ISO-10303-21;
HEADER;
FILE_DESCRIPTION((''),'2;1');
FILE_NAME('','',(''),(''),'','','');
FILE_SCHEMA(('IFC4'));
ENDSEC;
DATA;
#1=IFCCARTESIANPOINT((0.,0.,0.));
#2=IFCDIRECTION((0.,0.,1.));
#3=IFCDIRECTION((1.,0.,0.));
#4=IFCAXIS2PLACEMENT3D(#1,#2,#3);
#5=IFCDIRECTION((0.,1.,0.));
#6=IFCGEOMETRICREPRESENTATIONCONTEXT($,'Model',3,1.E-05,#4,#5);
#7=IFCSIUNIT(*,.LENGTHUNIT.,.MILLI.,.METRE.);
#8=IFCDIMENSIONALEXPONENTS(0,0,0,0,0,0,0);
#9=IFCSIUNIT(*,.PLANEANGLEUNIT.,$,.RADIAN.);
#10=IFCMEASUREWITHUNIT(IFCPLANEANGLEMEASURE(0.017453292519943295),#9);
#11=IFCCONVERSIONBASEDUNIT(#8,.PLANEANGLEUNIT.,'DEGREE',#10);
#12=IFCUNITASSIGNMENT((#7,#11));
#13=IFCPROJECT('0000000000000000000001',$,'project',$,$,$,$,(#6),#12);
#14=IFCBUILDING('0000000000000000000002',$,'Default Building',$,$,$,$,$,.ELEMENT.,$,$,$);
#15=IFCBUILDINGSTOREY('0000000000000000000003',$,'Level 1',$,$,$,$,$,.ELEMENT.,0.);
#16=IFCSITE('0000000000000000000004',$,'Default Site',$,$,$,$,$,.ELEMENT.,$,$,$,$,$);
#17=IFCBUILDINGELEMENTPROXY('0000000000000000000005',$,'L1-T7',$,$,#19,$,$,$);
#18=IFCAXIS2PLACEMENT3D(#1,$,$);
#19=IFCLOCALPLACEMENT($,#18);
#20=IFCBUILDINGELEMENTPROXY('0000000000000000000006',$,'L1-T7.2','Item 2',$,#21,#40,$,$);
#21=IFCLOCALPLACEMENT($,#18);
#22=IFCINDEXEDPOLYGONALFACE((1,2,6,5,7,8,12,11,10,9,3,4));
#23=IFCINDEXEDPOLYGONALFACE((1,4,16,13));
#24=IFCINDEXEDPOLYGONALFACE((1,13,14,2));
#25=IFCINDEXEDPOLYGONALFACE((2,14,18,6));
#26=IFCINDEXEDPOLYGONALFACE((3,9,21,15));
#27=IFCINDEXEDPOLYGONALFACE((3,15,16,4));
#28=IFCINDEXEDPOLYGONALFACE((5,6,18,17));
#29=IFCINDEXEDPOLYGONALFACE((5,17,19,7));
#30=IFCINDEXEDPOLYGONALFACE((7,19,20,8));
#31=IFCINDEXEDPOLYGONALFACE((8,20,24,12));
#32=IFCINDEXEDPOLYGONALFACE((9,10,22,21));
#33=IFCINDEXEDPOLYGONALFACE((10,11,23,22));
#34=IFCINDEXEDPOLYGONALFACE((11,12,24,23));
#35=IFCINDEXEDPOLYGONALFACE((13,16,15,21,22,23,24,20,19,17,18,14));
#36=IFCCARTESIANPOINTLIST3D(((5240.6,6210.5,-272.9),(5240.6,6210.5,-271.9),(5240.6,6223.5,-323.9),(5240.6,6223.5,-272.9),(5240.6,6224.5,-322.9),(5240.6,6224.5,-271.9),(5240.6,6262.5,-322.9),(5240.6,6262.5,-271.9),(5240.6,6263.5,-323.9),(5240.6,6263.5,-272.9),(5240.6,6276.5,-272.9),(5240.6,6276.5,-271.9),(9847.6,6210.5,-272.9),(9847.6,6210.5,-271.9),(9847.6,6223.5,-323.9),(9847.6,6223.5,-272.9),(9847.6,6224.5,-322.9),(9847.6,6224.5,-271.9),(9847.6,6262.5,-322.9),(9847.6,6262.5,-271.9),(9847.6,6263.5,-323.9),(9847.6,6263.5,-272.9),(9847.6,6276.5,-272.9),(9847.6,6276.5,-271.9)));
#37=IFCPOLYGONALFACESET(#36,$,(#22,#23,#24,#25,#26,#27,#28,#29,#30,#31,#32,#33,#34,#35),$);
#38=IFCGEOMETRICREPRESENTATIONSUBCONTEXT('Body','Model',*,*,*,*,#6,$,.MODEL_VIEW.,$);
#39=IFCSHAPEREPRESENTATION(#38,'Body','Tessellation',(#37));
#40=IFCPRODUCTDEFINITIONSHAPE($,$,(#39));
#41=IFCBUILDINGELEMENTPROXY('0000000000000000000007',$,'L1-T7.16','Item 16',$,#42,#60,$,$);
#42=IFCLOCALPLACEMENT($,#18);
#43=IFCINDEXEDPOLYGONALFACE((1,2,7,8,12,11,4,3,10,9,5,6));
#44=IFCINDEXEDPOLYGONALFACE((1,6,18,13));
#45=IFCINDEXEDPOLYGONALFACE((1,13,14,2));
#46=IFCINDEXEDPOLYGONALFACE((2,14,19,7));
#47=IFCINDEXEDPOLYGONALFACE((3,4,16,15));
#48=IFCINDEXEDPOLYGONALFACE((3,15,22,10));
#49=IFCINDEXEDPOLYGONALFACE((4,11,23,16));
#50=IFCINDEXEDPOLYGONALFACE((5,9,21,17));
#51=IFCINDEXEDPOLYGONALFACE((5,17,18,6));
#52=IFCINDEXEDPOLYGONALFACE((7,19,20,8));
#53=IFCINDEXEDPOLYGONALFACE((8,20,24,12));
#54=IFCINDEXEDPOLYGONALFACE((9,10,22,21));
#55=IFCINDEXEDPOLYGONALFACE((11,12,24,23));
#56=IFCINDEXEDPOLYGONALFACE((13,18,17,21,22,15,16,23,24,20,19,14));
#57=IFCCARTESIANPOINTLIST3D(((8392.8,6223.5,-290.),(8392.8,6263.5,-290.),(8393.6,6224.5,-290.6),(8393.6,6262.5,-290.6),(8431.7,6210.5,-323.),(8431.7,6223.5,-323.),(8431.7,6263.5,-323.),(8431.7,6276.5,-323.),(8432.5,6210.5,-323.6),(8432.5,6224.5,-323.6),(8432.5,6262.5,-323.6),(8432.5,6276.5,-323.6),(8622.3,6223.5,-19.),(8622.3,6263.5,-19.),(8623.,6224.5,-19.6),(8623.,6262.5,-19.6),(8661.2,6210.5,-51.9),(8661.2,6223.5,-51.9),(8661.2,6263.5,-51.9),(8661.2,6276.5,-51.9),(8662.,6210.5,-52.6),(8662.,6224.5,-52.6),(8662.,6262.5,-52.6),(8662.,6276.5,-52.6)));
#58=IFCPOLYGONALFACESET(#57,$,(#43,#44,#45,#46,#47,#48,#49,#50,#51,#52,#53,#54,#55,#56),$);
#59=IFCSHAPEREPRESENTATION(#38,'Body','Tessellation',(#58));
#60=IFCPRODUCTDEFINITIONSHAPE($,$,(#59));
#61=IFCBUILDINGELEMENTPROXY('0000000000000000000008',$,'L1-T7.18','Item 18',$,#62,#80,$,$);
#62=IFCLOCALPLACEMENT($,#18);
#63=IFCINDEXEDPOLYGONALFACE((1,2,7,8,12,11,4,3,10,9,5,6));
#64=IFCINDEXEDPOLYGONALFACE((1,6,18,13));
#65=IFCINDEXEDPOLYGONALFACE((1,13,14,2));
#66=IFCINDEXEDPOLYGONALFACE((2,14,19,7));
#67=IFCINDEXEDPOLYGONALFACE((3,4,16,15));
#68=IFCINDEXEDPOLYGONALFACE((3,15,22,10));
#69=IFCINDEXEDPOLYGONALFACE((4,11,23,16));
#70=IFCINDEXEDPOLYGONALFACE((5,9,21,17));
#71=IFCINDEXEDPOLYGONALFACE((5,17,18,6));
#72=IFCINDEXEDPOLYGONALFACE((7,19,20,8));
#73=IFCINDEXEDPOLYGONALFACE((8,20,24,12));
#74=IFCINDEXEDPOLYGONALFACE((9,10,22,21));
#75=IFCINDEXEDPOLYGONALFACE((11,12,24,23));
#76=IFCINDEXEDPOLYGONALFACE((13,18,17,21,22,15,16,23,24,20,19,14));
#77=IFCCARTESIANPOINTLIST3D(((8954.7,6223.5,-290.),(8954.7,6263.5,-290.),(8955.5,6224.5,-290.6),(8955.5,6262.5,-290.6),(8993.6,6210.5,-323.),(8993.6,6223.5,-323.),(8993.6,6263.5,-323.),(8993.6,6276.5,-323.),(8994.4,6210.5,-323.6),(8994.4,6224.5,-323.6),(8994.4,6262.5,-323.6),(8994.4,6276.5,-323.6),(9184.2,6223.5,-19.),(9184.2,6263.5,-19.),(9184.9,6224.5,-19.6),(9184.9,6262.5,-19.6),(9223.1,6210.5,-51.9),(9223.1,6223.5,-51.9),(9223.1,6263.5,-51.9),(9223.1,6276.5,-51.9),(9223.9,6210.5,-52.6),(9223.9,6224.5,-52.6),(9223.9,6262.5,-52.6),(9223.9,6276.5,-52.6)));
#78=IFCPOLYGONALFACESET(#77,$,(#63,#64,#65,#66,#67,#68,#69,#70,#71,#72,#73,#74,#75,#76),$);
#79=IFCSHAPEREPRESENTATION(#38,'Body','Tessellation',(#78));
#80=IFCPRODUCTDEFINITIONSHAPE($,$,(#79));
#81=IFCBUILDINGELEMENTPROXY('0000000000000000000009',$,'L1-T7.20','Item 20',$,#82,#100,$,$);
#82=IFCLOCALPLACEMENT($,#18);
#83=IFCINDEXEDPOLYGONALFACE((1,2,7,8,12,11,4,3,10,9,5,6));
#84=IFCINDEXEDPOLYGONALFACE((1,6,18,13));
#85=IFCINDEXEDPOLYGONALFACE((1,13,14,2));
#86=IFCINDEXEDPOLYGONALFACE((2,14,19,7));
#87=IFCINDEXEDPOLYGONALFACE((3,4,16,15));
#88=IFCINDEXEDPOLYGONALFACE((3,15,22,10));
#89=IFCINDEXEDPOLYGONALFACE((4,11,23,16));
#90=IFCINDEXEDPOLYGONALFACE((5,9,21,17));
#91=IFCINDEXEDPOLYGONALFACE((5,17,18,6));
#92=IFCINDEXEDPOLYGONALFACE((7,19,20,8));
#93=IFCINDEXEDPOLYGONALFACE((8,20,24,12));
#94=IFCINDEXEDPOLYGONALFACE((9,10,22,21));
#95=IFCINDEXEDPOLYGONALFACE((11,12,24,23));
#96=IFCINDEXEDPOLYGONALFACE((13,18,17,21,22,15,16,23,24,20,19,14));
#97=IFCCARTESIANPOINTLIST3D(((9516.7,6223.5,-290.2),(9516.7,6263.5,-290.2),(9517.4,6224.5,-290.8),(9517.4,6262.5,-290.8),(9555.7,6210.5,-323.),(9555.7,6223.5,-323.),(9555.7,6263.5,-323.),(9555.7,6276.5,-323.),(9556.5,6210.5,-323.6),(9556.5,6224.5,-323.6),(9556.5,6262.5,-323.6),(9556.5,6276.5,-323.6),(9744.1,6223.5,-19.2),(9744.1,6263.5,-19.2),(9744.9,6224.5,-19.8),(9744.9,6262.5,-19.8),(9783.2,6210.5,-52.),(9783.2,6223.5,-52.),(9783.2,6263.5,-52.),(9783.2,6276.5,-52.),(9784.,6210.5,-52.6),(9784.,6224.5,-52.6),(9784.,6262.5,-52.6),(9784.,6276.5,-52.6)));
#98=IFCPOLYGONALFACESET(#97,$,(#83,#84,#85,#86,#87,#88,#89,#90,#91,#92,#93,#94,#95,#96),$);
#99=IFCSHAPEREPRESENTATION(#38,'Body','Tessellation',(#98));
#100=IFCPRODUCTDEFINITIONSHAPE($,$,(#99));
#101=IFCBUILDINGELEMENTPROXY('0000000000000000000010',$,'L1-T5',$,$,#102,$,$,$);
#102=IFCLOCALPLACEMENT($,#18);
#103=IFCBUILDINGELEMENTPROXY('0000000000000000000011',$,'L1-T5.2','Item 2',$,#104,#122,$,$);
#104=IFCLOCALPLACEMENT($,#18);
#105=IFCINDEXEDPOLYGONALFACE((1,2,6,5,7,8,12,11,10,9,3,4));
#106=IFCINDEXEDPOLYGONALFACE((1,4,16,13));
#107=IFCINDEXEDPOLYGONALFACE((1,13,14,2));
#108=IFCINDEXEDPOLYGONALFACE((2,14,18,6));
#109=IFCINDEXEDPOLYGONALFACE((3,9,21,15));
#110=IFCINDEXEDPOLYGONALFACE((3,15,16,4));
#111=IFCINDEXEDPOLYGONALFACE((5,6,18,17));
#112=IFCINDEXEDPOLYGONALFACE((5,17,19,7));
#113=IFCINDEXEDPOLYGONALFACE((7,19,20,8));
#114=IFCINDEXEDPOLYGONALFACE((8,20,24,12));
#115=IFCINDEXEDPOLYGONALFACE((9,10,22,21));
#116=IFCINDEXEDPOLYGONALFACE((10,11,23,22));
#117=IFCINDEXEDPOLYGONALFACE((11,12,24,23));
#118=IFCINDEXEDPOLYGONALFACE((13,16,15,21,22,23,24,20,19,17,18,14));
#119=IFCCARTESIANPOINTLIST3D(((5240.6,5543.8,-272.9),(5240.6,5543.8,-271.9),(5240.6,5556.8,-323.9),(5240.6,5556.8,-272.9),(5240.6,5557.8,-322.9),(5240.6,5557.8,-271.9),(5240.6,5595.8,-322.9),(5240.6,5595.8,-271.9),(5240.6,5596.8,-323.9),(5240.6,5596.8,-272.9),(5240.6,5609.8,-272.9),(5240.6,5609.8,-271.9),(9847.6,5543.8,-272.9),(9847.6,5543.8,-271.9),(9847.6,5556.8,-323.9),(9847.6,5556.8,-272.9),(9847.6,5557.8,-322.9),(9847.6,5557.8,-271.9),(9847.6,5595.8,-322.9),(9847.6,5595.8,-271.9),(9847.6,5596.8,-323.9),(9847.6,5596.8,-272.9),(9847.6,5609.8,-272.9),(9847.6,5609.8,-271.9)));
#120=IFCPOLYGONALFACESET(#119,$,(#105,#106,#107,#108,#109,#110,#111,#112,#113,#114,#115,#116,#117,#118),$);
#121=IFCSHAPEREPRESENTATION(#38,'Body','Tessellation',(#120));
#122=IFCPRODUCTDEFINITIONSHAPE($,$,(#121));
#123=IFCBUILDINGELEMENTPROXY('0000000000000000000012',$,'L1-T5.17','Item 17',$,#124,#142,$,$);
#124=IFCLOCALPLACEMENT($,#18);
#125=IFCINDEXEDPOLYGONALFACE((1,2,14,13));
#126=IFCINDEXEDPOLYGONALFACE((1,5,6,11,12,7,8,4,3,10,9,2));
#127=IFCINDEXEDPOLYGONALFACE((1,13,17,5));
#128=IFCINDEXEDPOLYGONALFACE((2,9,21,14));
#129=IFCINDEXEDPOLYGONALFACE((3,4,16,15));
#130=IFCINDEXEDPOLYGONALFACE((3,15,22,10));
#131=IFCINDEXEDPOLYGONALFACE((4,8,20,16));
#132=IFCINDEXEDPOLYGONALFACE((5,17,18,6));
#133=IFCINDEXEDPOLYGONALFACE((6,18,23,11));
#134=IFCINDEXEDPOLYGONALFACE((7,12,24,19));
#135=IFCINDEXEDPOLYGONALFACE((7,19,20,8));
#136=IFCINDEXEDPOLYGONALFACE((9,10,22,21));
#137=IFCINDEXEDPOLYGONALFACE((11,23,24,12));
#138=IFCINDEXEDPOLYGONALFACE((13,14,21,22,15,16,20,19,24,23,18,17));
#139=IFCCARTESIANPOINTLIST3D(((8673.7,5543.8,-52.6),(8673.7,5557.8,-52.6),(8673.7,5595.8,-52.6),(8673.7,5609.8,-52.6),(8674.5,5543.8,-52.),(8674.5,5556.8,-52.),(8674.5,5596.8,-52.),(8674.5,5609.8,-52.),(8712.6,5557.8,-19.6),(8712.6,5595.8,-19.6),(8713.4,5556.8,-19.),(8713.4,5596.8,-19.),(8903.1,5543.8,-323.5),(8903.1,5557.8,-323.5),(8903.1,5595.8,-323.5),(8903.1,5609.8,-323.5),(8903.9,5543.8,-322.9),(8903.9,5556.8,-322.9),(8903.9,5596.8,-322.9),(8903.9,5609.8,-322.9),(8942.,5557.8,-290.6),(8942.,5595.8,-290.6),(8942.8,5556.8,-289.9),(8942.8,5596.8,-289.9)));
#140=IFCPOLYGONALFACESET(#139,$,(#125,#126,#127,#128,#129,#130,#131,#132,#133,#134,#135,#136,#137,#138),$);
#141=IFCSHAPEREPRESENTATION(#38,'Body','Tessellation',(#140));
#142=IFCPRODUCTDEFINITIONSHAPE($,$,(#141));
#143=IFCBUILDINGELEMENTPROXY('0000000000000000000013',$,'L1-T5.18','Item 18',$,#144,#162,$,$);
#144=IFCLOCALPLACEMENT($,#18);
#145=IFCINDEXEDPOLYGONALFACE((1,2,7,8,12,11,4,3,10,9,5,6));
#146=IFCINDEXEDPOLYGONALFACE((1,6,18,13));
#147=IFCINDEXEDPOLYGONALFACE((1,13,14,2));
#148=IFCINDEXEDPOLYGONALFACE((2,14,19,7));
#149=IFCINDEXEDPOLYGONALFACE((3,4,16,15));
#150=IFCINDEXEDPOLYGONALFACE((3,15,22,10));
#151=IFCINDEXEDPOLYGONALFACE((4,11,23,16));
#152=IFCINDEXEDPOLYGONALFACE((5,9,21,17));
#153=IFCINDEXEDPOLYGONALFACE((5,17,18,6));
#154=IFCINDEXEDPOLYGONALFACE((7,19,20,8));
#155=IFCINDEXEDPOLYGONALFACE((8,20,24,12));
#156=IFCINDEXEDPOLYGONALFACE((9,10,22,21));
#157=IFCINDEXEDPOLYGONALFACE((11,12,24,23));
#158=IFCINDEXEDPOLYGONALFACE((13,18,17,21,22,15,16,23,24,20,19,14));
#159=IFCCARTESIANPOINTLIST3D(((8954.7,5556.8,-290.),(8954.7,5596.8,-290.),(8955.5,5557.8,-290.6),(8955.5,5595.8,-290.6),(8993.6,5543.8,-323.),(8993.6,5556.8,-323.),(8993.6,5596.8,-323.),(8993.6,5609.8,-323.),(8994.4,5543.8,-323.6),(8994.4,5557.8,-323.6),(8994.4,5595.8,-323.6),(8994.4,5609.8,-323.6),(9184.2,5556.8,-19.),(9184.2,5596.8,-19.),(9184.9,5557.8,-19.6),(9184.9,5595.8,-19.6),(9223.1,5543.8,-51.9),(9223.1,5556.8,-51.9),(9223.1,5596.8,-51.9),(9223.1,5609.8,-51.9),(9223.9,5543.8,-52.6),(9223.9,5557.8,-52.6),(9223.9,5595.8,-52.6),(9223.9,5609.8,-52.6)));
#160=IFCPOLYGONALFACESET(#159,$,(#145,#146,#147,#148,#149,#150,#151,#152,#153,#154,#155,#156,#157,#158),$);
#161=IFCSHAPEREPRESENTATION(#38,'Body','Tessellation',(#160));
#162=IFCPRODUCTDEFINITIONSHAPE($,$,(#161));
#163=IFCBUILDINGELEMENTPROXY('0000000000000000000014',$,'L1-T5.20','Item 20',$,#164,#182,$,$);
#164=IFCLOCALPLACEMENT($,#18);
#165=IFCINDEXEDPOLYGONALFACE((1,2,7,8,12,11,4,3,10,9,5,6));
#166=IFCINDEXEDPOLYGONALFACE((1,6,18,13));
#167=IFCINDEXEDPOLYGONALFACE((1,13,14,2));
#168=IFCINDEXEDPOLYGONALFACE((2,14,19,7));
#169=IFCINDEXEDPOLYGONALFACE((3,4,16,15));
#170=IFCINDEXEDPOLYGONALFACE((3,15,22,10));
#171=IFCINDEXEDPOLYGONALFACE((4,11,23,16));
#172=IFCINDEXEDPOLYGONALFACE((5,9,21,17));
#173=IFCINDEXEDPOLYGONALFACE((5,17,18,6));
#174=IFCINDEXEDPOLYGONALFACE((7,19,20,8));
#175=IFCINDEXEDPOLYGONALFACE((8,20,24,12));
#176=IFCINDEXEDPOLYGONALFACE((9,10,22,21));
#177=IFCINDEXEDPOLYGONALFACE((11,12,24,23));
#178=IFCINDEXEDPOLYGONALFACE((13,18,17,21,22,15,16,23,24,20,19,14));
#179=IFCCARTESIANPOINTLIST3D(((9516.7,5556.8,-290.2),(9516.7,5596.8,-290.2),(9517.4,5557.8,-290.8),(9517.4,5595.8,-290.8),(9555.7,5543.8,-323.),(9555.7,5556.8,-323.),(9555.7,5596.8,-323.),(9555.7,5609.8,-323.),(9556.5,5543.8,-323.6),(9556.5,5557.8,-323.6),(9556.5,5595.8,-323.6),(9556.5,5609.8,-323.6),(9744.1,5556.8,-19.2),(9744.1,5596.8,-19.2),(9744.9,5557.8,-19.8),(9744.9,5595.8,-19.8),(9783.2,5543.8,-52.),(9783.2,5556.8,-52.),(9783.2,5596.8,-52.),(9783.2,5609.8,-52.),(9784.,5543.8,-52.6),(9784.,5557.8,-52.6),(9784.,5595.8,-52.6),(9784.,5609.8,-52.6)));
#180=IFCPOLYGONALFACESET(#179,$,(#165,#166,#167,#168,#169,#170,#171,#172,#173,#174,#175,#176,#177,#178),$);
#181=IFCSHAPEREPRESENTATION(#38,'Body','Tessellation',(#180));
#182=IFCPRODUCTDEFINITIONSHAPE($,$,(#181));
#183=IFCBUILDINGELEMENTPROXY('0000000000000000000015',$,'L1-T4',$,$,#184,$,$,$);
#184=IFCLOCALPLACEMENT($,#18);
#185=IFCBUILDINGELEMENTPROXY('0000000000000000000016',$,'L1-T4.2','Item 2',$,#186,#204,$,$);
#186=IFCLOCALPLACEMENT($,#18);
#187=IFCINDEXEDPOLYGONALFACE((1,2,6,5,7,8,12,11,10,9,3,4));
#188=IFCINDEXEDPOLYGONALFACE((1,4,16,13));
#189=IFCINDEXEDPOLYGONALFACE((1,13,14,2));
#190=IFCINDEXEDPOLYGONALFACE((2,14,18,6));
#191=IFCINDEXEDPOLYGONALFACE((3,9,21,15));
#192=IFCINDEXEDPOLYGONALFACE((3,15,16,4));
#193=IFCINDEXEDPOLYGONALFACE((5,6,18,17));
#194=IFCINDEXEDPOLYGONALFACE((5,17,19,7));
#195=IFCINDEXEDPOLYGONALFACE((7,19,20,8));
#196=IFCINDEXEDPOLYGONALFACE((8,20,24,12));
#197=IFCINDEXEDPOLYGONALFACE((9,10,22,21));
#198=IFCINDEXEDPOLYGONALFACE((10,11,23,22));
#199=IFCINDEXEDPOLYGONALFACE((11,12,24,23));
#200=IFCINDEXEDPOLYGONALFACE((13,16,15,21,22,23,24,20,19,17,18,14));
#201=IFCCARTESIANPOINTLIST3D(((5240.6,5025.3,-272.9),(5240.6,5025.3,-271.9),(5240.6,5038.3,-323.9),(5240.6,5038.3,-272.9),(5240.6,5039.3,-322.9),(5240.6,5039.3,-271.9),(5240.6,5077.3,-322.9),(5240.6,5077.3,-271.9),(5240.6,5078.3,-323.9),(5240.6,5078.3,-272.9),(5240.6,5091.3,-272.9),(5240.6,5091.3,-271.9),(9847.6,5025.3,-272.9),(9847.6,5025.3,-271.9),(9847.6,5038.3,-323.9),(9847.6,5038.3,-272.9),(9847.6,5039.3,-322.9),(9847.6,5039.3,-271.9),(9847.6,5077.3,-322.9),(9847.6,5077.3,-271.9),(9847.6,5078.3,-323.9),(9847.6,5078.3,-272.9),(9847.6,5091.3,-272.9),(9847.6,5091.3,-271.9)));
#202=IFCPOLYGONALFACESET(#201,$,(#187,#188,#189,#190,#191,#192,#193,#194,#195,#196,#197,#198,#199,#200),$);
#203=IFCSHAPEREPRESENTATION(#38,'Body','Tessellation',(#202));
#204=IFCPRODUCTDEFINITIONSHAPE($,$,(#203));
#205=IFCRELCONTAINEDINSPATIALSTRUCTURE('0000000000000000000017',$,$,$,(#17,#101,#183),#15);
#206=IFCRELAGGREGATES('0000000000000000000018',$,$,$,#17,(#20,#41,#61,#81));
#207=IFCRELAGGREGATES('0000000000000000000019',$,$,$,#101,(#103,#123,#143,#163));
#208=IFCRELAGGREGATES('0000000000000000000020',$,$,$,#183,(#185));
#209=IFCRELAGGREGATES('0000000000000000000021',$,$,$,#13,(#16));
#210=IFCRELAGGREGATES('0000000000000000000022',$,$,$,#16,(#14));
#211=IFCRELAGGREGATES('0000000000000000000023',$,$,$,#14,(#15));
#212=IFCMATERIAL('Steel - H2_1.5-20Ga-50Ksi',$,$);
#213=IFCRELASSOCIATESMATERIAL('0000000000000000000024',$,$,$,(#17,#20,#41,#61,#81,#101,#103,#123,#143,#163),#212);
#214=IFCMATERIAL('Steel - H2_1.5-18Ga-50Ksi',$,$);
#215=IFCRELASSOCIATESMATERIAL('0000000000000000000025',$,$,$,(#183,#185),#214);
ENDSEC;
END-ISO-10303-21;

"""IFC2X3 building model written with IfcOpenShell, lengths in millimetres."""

from ifc_helpers import new_model, entity, si_unit, converted_unit, direction, frame, origin, origin_with_axes, place, context, subcontext, project, spatial, polyline, outline, extrude, material, element, aggregate, save


model = new_model("IFC2X3")

# Units and contexts
model_context = context("Model", 3, precision=1e-05, world=origin_with_axes(), true_north=direction((0.0, 1.0, 0.0)))
body_context = subcontext(model_context, "Body", "Model", "MODEL_VIEW")
ifc_project = project(units=[si_unit("LENGTHUNIT", "METRE", prefix="MILLI"), converted_unit("PLANEANGLEUNIT", "DEGREE", entity("IfcPlaneAngleMeasure", 0.017453292519943295), si_unit("PLANEANGLEUNIT", "RADIAN"), dimensions=[0, 0, 0, 0, 0, 0, 0])], contexts=[model_context])

# Site, building, storey
site = spatial("IfcSite", under=ifc_project, Name="Default Site", CompositionType="ELEMENT")
building = spatial("IfcBuilding", under=site, Name="Default Building", CompositionType="ELEMENT")
storey = spatial("IfcBuildingStorey", under=building, Name="Level 1", CompositionType="ELEMENT", Elevation=0.0)

# Building element proxies
ifc_material_1 = material(Name="Steel - H2_1.5-20Ga-50Ksi")
proxy_1 = element("IfcBuildingElementProxy", 1, inside=storey, material=ifc_material_1, Name="L1-T7")
proxy_2_placement = place(None, frame((9847.6, 6210.5, -271.9), z_axis=(-1.0, 0.0, 0.0), x_axis=(0.0, 108.0, 0.0)))
proxy_2 = element("IfcBuildingElementProxy", 2, at=proxy_2_placement, material=ifc_material_1, Name="L1-T7.2", Description="Item 2", context=body_context, shape_type="SweptSolid", body=[
    extrude(outline(polyline([(0.0, 0.0), (14.0, 0.0), (14.0, 51.0), (52.0, 51.0), (52.0, 0.0), (66.0, 0.0), (66.0, 1.0), (53.0, 1.0), (53.0, 52.0), (13.0, 52.0), (13.0, 1.0), (0.0, 1.0), (0.0, 0.0)])), origin(), (0.0, 0.0, 1.0), 4607.0),
])
proxy_3_placement = place(None, frame((8432.5, 6210.5, -323.6), z_axis=(0.646, 0.0, 0.763), x_axis=(0.0, 108.0, 0.0)))
proxy_3 = element("IfcBuildingElementProxy", 3, at=proxy_3_placement, material=ifc_material_1, Name="L1-T7.16", Description="Item 16", context=body_context, shape_type="SweptSolid", body=[
    extrude(outline(polyline([(0.0, 0.0), (14.0, 0.0), (14.0, 51.0), (52.0, 51.0), (52.0, 0.0), (66.0, 0.0), (66.0, 1.0), (53.0, 1.0), (53.0, 52.0), (13.0, 52.0), (13.0, 1.0), (0.0, 1.0), (0.0, 0.0)])), origin(), (0.0, 0.0, 1.0), 355.1),
])
proxy_4_placement = place(None, frame((8994.4, 6210.5, -323.6), z_axis=(0.646, 0.0, 0.763), x_axis=(0.0, 108.0, 0.0)))
proxy_4 = element("IfcBuildingElementProxy", 4, at=proxy_4_placement, material=ifc_material_1, Name="L1-T7.18", Description="Item 18", context=body_context, shape_type="SweptSolid", body=[
    extrude(outline(polyline([(0.0, 0.0), (14.0, 0.0), (14.0, 51.0), (52.0, 51.0), (52.0, 0.0), (66.0, 0.0), (66.0, 1.0), (53.0, 1.0), (53.0, 52.0), (13.0, 52.0), (13.0, 1.0), (0.0, 1.0), (0.0, 0.0)])), origin(), (0.0, 0.0, 1.0), 355.1),
])
proxy_5_placement = place(None, frame((9556.5, 6210.5, -323.6), z_axis=(0.643, 0.0, 0.766), x_axis=(0.0, 108.0, 0.0)))
proxy_5 = element("IfcBuildingElementProxy", 5, at=proxy_5_placement, material=ifc_material_1, Name="L1-T7.20", Description="Item 20", context=body_context, shape_type="SweptSolid", body=[
    extrude(outline(polyline([(0.0, 0.0), (14.0, 0.0), (14.0, 51.0), (52.0, 51.0), (52.0, 0.0), (66.0, 0.0), (66.0, 1.0), (53.0, 1.0), (53.0, 52.0), (13.0, 52.0), (13.0, 1.0), (0.0, 1.0), (0.0, 0.0)])), origin(), (0.0, 0.0, 1.0), 353.8),
])
aggregate(proxy_1, [proxy_2, proxy_3, proxy_4, proxy_5])
proxy_6 = element("IfcBuildingElementProxy", 6, inside=storey, material=ifc_material_1, Name="L1-T5")
proxy_7_placement = place(None, frame((9847.6, 5543.8, -271.9), z_axis=(-1.0, 0.0, 0.0), x_axis=(0.0, 108.0, 0.0)))
proxy_7 = element("IfcBuildingElementProxy", 7, at=proxy_7_placement, material=ifc_material_1, Name="L1-T5.2", Description="Item 2", context=body_context, shape_type="SweptSolid", body=[
    extrude(outline(polyline([(0.0, 0.0), (14.0, 0.0), (14.0, 51.0), (52.0, 51.0), (52.0, 0.0), (66.0, 0.0), (66.0, 1.0), (53.0, 1.0), (53.0, 52.0), (13.0, 52.0), (13.0, 1.0), (0.0, 1.0), (0.0, 0.0)])), origin(), (0.0, 0.0, 1.0), 4607.0),
])
proxy_8_placement = place(None, frame((8673.7, 5543.8, -52.6), z_axis=(0.646, 0.0, -0.763), x_axis=(0.0, 108.0, 0.0)))
proxy_8 = element("IfcBuildingElementProxy", 8, at=proxy_8_placement, material=ifc_material_1, Name="L1-T5.17", Description="Item 17", context=body_context, shape_type="SweptSolid", body=[
    extrude(outline(polyline([(0.0, 0.0), (14.0, 0.0), (14.0, 51.0), (52.0, 51.0), (52.0, 0.0), (66.0, 0.0), (66.0, 1.0), (53.0, 1.0), (53.0, 52.0), (13.0, 52.0), (13.0, 1.0), (0.0, 1.0), (0.0, 0.0)])), origin(), (0.0, 0.0, 1.0), 355.0),
])
proxy_9_placement = place(None, frame((8994.4, 5543.8, -323.6), z_axis=(0.646, 0.0, 0.763), x_axis=(0.0, 108.0, 0.0)))
proxy_9 = element("IfcBuildingElementProxy", 9, at=proxy_9_placement, material=ifc_material_1, Name="L1-T5.18", Description="Item 18", context=body_context, shape_type="SweptSolid", body=[
    extrude(outline(polyline([(0.0, 0.0), (14.0, 0.0), (14.0, 51.0), (52.0, 51.0), (52.0, 0.0), (66.0, 0.0), (66.0, 1.0), (53.0, 1.0), (53.0, 52.0), (13.0, 52.0), (13.0, 1.0), (0.0, 1.0), (0.0, 0.0)])), origin(), (0.0, 0.0, 1.0), 355.1),
])
proxy_10_placement = place(None, frame((9556.5, 5543.8, -323.6), z_axis=(0.643, 0.0, 0.766), x_axis=(0.0, 108.0, 0.0)))
proxy_10 = element("IfcBuildingElementProxy", 10, at=proxy_10_placement, material=ifc_material_1, Name="L1-T5.20", Description="Item 20", context=body_context, shape_type="SweptSolid", body=[
    extrude(outline(polyline([(0.0, 0.0), (14.0, 0.0), (14.0, 51.0), (52.0, 51.0), (52.0, 0.0), (66.0, 0.0), (66.0, 1.0), (53.0, 1.0), (53.0, 52.0), (13.0, 52.0), (13.0, 1.0), (0.0, 1.0), (0.0, 0.0)])), origin(), (0.0, 0.0, 1.0), 353.8),
])
aggregate(proxy_6, [proxy_7, proxy_8, proxy_9, proxy_10])
ifc_material_2 = material(Name="Steel - H2_1.5-18Ga-50Ksi")
proxy_11 = element("IfcBuildingElementProxy", 11, inside=storey, material=ifc_material_2, Name="L1-T4")
proxy_12_placement = place(None, frame((9847.6, 5025.3, -271.9), z_axis=(-1.0, 0.0, 0.0), x_axis=(0.0, 40.0, 0.0)))
proxy_12 = element("IfcBuildingElementProxy", 12, at=proxy_12_placement, material=ifc_material_2, Name="L1-T4.2", Description="Item 2", context=body_context, shape_type="SweptSolid", body=[
    extrude(outline(polyline([(0.0, 0.0), (14.0, 0.0), (14.0, 51.0), (52.0, 51.0), (52.0, 0.0), (66.0, 0.0), (66.0, 1.0), (53.0, 1.0), (53.0, 52.0), (13.0, 52.0), (13.0, 1.0), (0.0, 1.0), (0.0, 0.0)])), origin(), (0.0, 0.0, 1.0), 4607.0),
])
aggregate(proxy_11, [proxy_12])

save(model, "model.ifc")
